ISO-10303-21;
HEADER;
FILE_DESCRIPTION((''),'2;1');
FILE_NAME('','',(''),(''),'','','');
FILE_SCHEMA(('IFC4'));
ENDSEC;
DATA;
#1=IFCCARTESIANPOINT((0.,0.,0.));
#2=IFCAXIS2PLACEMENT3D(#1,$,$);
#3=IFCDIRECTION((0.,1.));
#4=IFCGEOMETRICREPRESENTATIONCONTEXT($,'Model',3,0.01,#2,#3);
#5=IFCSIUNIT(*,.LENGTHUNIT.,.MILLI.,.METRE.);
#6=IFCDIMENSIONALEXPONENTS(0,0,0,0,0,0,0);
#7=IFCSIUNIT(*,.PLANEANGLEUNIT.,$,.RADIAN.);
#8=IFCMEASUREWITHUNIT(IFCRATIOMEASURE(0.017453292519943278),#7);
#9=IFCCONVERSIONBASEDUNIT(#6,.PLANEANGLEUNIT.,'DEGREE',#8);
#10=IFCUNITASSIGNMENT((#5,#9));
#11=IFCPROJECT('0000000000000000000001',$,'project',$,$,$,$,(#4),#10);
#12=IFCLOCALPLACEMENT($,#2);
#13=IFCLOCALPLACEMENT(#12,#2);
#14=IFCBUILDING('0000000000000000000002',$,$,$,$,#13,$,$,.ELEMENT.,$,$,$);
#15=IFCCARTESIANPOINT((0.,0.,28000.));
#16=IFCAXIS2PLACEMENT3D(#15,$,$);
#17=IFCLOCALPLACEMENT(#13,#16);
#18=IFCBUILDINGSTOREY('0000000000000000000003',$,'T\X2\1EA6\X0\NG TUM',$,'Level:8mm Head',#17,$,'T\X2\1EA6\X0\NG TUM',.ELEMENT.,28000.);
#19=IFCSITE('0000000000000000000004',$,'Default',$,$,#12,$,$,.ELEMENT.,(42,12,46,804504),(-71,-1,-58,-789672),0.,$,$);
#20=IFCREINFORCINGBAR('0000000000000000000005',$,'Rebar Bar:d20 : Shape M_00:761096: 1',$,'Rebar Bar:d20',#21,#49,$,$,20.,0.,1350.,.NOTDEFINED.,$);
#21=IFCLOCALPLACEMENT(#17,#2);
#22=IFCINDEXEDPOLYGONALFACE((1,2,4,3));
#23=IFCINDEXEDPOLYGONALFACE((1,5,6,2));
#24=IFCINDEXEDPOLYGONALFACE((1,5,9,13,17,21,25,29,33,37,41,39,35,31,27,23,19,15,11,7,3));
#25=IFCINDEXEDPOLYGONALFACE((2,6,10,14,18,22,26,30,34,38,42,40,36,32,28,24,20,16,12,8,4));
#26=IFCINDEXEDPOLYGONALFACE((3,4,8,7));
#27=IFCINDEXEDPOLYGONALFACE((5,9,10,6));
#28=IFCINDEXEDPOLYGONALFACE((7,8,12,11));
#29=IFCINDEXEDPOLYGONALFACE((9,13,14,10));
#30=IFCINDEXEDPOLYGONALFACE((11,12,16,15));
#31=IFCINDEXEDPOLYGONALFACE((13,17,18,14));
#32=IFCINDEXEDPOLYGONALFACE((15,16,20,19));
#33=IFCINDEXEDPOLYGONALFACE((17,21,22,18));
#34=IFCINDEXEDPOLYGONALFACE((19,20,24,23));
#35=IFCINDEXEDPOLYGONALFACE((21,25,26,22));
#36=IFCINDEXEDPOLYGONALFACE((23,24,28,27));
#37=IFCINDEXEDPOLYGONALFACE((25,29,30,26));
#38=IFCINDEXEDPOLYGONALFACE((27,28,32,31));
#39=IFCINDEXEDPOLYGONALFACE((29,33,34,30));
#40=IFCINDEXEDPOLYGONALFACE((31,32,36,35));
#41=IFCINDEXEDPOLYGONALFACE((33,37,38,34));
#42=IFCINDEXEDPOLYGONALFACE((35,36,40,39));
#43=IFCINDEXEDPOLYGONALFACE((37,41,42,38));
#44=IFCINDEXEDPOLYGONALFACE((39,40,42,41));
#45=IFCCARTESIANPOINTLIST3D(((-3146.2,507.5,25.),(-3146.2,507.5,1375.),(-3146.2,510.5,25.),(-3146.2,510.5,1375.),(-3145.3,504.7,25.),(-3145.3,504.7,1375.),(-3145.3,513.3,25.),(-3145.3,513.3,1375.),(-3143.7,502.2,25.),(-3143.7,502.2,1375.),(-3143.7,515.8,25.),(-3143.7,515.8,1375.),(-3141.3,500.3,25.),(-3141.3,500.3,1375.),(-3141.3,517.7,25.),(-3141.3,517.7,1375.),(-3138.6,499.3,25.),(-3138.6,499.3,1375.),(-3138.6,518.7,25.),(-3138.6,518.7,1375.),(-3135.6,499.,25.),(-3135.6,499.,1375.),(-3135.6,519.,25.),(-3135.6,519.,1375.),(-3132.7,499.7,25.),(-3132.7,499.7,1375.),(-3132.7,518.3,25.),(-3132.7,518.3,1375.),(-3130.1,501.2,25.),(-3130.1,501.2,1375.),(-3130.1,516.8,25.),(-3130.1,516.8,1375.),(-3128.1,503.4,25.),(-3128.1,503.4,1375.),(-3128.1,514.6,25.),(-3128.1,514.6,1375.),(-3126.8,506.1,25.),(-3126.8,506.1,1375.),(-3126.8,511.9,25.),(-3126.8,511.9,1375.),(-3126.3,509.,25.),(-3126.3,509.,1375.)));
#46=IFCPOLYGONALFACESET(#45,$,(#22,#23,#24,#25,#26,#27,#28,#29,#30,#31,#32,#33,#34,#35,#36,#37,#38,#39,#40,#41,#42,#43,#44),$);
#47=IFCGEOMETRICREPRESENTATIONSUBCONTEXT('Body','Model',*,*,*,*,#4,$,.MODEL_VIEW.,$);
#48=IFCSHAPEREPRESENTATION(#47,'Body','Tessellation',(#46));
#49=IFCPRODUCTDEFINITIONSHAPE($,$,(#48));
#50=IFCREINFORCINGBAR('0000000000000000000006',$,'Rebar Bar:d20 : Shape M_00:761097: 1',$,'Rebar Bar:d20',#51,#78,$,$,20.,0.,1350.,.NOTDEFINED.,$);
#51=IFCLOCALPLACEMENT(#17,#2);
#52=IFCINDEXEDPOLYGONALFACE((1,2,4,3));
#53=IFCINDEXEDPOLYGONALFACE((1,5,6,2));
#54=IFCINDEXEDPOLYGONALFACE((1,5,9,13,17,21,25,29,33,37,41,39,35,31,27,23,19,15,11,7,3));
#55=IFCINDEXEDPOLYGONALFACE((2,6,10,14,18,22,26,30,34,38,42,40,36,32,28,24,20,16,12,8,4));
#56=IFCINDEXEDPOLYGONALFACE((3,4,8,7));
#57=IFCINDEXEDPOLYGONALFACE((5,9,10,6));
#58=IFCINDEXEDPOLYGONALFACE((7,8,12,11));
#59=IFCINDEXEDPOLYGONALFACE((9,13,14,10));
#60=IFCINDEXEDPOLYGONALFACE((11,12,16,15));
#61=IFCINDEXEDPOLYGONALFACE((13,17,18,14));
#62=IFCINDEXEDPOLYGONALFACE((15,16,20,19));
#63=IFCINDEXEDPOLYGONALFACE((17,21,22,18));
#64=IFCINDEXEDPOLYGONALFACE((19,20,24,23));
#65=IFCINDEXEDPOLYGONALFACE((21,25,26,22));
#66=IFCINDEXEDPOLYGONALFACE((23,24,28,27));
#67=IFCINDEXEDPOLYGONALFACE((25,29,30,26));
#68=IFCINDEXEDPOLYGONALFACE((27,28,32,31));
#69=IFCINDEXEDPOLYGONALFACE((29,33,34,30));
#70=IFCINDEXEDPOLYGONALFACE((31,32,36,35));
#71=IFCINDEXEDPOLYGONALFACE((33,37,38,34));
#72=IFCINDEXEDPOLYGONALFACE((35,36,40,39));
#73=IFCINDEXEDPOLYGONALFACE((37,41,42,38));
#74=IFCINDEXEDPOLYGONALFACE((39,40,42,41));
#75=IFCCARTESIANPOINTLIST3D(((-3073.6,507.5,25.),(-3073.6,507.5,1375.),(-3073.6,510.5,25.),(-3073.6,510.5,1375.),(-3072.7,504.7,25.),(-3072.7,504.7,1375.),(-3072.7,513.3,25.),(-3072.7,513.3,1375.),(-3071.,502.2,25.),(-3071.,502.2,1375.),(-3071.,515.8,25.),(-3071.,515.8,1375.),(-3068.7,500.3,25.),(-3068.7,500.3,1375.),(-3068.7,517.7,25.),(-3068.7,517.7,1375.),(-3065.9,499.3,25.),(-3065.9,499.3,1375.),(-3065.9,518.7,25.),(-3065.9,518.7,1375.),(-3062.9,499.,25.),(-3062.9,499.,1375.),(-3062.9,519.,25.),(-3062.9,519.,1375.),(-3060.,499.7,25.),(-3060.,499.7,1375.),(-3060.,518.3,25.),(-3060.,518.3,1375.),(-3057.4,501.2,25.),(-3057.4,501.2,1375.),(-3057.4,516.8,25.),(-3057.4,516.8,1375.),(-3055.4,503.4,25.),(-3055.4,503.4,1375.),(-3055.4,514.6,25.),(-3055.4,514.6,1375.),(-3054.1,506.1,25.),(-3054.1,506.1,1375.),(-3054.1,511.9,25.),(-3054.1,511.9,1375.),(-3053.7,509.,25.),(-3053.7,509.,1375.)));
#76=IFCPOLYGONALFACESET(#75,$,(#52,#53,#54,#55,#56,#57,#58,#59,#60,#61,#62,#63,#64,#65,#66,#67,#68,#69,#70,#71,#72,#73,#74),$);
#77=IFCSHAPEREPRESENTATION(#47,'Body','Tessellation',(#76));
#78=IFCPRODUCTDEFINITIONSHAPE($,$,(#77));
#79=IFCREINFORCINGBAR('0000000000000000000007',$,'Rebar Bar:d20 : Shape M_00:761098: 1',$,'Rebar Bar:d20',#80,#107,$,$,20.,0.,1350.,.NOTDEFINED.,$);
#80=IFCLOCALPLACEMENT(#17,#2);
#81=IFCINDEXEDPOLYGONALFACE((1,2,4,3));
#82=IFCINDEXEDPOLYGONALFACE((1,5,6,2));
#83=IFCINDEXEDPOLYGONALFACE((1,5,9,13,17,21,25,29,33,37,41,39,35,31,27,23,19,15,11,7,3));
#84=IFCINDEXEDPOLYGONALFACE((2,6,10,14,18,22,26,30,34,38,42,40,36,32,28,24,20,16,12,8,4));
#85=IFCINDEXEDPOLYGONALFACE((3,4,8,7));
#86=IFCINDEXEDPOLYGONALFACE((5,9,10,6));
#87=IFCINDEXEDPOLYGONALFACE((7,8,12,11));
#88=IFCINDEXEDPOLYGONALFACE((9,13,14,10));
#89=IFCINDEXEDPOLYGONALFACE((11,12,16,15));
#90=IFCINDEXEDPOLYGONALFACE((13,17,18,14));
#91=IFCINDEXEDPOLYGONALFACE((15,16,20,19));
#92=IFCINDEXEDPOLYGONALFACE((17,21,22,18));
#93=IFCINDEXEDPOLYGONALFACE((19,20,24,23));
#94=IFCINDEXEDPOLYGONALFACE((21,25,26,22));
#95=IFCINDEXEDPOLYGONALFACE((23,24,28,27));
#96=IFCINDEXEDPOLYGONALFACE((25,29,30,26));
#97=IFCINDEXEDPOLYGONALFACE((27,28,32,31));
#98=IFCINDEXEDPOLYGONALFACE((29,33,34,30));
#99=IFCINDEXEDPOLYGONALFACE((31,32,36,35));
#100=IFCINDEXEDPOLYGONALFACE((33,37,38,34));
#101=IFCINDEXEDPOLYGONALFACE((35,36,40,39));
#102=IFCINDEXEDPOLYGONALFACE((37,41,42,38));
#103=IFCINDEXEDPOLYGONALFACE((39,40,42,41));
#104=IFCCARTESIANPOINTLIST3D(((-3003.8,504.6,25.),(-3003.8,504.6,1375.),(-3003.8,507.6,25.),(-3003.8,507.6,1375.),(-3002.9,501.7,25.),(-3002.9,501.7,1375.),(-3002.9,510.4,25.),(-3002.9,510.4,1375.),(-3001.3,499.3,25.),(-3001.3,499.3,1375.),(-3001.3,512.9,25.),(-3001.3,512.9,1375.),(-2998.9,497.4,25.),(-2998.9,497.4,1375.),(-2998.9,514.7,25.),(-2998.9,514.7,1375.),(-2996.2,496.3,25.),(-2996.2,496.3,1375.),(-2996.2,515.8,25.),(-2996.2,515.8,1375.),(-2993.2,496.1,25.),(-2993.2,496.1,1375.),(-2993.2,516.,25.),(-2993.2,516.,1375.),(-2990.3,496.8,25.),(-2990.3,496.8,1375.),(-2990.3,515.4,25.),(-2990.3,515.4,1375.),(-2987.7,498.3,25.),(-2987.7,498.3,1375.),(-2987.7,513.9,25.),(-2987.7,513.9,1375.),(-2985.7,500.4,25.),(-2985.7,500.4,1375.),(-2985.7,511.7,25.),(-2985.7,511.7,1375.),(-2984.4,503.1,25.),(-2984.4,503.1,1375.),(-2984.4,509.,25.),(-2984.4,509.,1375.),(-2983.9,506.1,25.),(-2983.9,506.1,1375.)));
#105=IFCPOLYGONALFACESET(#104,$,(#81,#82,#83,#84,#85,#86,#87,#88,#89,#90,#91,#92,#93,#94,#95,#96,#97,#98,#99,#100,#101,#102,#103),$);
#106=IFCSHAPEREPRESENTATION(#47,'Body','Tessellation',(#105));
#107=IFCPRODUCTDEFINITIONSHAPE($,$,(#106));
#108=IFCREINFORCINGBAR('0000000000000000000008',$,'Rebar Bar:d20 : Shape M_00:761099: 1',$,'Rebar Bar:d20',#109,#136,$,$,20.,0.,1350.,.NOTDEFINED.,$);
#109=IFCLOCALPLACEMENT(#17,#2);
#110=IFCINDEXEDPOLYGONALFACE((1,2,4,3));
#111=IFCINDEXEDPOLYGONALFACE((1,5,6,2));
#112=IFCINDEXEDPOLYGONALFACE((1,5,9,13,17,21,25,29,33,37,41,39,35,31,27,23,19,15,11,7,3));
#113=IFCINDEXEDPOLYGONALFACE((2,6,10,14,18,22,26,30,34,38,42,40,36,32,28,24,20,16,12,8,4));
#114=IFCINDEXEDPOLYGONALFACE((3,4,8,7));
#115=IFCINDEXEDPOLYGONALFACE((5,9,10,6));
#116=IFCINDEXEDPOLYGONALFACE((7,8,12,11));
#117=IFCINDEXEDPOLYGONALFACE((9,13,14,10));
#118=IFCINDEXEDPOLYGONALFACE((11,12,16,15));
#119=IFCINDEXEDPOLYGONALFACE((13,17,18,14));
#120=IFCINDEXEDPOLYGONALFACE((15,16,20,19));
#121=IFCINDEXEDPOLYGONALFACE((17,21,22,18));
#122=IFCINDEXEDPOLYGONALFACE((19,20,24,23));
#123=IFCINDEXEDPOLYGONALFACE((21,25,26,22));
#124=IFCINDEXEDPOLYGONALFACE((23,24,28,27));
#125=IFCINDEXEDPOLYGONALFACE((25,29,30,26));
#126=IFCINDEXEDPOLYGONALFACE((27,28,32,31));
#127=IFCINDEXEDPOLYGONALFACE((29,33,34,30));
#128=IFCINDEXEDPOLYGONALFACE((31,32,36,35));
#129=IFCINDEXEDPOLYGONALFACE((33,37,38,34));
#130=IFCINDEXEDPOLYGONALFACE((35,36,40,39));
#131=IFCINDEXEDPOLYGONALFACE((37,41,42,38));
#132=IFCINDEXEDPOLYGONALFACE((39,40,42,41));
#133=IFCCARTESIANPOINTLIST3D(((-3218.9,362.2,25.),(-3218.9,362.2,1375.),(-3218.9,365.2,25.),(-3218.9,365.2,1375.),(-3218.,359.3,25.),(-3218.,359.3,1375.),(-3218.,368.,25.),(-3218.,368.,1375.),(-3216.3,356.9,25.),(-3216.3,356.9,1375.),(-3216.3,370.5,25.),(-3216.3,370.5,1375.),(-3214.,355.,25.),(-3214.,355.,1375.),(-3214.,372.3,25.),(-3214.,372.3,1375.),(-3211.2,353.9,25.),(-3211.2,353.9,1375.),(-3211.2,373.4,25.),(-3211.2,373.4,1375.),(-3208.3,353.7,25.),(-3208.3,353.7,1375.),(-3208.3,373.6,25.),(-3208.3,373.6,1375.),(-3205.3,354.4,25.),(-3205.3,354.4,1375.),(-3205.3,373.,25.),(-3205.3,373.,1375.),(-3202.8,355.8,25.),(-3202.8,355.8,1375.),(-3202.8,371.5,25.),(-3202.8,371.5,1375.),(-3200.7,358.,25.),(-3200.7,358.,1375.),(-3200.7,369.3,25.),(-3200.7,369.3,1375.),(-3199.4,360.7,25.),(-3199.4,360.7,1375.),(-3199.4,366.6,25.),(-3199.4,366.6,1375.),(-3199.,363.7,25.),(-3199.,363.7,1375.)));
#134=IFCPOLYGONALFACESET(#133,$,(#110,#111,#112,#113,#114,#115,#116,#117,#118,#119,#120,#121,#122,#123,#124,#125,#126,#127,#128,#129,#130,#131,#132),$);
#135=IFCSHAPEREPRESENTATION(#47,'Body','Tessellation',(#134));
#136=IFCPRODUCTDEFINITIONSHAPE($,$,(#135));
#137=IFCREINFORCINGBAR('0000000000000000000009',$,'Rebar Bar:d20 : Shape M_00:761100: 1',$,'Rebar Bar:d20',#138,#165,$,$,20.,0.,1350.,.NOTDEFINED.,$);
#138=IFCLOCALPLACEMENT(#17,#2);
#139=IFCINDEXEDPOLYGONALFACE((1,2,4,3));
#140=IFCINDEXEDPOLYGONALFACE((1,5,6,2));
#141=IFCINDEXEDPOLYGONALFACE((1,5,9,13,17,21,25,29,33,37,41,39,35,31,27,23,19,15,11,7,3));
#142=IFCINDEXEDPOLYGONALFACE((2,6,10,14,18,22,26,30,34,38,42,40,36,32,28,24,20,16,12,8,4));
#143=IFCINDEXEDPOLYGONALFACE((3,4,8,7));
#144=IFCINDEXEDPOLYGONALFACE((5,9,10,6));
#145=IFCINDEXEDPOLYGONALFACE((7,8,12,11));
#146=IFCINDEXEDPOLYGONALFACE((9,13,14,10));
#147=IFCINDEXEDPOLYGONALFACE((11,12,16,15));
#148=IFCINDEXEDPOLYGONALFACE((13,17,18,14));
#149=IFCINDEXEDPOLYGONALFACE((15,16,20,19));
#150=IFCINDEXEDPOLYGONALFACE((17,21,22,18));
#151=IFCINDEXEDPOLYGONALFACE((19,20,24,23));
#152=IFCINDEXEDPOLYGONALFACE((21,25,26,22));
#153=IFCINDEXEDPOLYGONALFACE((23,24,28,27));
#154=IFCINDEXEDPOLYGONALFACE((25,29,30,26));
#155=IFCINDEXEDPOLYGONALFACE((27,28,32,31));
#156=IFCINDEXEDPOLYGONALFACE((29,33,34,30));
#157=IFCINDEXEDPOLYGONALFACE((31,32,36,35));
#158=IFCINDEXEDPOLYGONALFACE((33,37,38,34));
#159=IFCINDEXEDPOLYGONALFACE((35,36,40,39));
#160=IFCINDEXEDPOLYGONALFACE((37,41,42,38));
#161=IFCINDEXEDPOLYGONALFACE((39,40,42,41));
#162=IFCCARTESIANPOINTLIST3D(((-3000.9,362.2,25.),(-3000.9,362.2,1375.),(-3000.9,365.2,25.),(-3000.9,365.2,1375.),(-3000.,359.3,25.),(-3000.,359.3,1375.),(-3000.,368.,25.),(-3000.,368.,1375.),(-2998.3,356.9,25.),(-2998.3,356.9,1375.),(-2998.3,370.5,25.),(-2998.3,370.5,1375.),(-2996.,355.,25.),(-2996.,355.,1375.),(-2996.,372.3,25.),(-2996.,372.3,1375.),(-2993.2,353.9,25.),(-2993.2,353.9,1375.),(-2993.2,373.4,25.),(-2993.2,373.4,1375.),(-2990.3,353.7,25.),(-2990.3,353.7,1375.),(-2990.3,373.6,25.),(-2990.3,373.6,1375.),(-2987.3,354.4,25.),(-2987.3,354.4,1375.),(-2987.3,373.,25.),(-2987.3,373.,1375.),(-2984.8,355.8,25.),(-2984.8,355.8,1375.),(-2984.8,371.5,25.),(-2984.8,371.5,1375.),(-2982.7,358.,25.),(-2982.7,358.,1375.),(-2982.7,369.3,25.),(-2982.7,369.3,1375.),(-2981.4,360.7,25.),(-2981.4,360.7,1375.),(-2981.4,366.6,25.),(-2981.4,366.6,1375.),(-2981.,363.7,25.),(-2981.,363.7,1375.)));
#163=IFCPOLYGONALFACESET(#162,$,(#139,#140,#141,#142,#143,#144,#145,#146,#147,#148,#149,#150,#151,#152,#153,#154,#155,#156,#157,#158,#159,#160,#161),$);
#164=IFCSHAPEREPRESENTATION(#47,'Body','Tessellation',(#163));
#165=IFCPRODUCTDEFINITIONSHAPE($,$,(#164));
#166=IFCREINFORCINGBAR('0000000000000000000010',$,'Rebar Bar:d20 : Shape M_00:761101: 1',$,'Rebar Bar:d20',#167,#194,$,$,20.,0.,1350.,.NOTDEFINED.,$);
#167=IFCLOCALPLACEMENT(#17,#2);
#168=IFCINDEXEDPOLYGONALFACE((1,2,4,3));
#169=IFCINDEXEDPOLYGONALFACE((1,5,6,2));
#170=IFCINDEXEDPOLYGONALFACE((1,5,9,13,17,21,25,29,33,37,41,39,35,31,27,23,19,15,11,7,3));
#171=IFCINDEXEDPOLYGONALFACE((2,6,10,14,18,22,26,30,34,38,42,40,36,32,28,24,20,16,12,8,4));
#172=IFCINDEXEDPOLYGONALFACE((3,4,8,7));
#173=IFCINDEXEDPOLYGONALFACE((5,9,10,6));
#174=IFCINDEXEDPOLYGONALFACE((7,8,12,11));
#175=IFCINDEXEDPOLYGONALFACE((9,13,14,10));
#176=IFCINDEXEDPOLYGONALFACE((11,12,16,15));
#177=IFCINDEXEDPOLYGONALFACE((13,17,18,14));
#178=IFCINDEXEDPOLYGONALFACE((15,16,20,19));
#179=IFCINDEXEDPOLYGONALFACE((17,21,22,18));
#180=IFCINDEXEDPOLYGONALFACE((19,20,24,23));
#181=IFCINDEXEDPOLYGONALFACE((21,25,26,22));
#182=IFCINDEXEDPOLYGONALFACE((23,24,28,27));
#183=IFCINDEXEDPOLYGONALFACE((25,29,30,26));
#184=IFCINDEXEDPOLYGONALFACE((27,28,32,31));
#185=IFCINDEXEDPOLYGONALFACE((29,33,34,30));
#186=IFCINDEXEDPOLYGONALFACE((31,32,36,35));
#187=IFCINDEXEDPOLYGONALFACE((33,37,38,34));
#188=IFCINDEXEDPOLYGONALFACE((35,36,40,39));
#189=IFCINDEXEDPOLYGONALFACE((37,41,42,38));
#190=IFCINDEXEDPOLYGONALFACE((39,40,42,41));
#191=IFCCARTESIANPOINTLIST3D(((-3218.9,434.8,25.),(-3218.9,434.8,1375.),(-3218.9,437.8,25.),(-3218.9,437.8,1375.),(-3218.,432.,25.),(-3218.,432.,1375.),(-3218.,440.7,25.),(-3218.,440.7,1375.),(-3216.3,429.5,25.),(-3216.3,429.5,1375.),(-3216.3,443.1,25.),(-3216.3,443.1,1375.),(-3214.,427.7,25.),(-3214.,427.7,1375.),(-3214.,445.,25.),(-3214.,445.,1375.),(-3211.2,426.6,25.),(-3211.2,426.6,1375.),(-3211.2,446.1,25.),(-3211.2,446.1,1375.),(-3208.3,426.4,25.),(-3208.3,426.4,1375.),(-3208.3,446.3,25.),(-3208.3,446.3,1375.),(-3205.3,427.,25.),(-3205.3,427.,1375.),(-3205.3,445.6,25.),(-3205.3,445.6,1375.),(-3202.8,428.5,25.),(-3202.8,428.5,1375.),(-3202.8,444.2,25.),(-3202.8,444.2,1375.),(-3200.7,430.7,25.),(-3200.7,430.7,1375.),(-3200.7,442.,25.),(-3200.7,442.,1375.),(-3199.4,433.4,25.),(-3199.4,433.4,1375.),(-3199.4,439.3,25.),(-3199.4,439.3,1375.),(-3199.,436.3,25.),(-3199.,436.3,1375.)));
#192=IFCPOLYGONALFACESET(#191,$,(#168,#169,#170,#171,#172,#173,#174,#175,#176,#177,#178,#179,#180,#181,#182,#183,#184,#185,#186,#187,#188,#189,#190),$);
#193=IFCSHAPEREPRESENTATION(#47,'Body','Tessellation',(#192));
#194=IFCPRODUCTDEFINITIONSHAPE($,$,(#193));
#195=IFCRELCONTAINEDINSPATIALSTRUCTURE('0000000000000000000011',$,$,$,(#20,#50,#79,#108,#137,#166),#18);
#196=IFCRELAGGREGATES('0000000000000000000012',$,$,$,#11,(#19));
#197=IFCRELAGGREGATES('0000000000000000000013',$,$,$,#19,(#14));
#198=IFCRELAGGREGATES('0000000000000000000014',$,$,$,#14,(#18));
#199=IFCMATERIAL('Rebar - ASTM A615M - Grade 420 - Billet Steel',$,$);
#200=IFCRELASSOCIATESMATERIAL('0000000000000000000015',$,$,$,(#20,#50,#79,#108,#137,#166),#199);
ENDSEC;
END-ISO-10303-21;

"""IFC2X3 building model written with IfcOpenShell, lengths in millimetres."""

from ifc_helpers import new_model, entity, si_unit, converted_unit, direction, frame, origin, place, context, subcontext, project, spatial, material, element, save


model = new_model("IFC2X3")

# Units and contexts
model_context = context("Model", 3, precision=0.01, world=origin(), true_north=direction((0.0, 1.0)))
body_context = subcontext(model_context, "Body", "Model", "MODEL_VIEW")
ifc_project = project(units=[si_unit("LENGTHUNIT", "METRE", prefix="MILLI"), converted_unit("PLANEANGLEUNIT", "DEGREE", entity("IfcRatioMeasure", 0.017453292519943278), si_unit("PLANEANGLEUNIT", "RADIAN"), dimensions=[0, 0, 0, 0, 0, 0, 0])], contexts=[model_context])

# Site, building, storey
site_placement = place(None, origin())
site = spatial("IfcSite", under=ifc_project, at=site_placement, Name="Default", CompositionType="ELEMENT", RefLatitude=(42, 12, 46, 804504), RefLongitude=(-71, -1, -58, -789672), RefElevation=0.0)
building_placement = place(site_placement, origin())
building = spatial("IfcBuilding", under=site, at=building_placement, CompositionType="ELEMENT")
storey_placement = place(building_placement, frame((0.0, 0.0, 28000.0)))
storey = spatial("IfcBuildingStorey", under=building, at=storey_placement, Name="TẦNG TUM", ObjectType="Level:8mm Head", LongName="TẦNG TUM", CompositionType="ELEMENT", Elevation=28000.0)

# Reinforcing bars
ifc_material = material(Name="Rebar - ASTM A615M - Grade 420 - Billet Steel")
reinforcing_bar_1_placement = place(storey_placement, origin())
element("IfcReinforcingBar", 1, at=reinforcing_bar_1_placement, inside=storey, material=ifc_material, Name="Rebar Bar:d20 : Shape M_00:761096: 1", ObjectType="Rebar Bar:d20", BarLength=1350.0, BarRole="NOTDEFINED", CrossSectionArea=0.0, NominalDiameter=20.0, context=body_context, shape_type="AdvancedSweptSolid", body=[
    entity("IfcSweptDiskSolid", entity("IfcCompositeCurve", [entity("IfcCompositeCurveSegment", "CONTINUOUS", True, entity("IfcPolyline", [entity("IfcCartesianPoint", [-3136.3, 509.0, 25.0]), entity("IfcCartesianPoint", [-3136.3, 509.0, 1375.0])]))], False), 10.0, None, 0.0, 1.0),
])
reinforcing_bar_2_placement = place(storey_placement, origin())
element("IfcReinforcingBar", 2, at=reinforcing_bar_2_placement, inside=storey, material=ifc_material, Name="Rebar Bar:d20 : Shape M_00:761097: 1", ObjectType="Rebar Bar:d20", BarLength=1350.0, BarRole="NOTDEFINED", CrossSectionArea=0.0, NominalDiameter=20.0, context=body_context, shape_type="AdvancedSweptSolid", body=[
    entity("IfcSweptDiskSolid", entity("IfcCompositeCurve", [entity("IfcCompositeCurveSegment", "CONTINUOUS", True, entity("IfcPolyline", [entity("IfcCartesianPoint", [-3063.7, 509.0, 25.0]), entity("IfcCartesianPoint", [-3063.7, 509.0, 1375.0])]))], False), 10.0, None, 0.0, 1.0),
])
reinforcing_bar_3_placement = place(storey_placement, origin())
element("IfcReinforcingBar", 3, at=reinforcing_bar_3_placement, inside=storey, material=ifc_material, Name="Rebar Bar:d20 : Shape M_00:761098: 1", ObjectType="Rebar Bar:d20", BarLength=1350.0, BarRole="NOTDEFINED", CrossSectionArea=0.0, NominalDiameter=20.0, context=body_context, shape_type="AdvancedSweptSolid", body=[
    entity("IfcSweptDiskSolid", entity("IfcCompositeCurve", [entity("IfcCompositeCurveSegment", "CONTINUOUS", True, entity("IfcPolyline", [entity("IfcCartesianPoint", [-2993.9, 506.1, 25.0]), entity("IfcCartesianPoint", [-2993.9, 506.1, 1375.0])]))], False), 10.0, None, 0.0, 1.0),
])
reinforcing_bar_4_placement = place(storey_placement, origin())
element("IfcReinforcingBar", 4, at=reinforcing_bar_4_placement, inside=storey, material=ifc_material, Name="Rebar Bar:d20 : Shape M_00:761099: 1", ObjectType="Rebar Bar:d20", BarLength=1350.0, BarRole="NOTDEFINED", CrossSectionArea=0.0, NominalDiameter=20.0, context=body_context, shape_type="AdvancedSweptSolid", body=[
    entity("IfcSweptDiskSolid", entity("IfcCompositeCurve", [entity("IfcCompositeCurveSegment", "CONTINUOUS", True, entity("IfcPolyline", [entity("IfcCartesianPoint", [-3209.0, 363.7, 25.0]), entity("IfcCartesianPoint", [-3209.0, 363.7, 1375.0])]))], False), 10.0, None, 0.0, 1.0),
])
reinforcing_bar_5_placement = place(storey_placement, origin())
element("IfcReinforcingBar", 5, at=reinforcing_bar_5_placement, inside=storey, material=ifc_material, Name="Rebar Bar:d20 : Shape M_00:761100: 1", ObjectType="Rebar Bar:d20", BarLength=1350.0, BarRole="NOTDEFINED", CrossSectionArea=0.0, NominalDiameter=20.0, context=body_context, shape_type="AdvancedSweptSolid", body=[
    entity("IfcSweptDiskSolid", entity("IfcCompositeCurve", [entity("IfcCompositeCurveSegment", "CONTINUOUS", True, entity("IfcPolyline", [entity("IfcCartesianPoint", [-2991.0, 363.7, 25.0]), entity("IfcCartesianPoint", [-2991.0, 363.7, 1375.0])]))], False), 10.0, None, 0.0, 1.0),
])
reinforcing_bar_6_placement = place(storey_placement, origin())
element("IfcReinforcingBar", 6, at=reinforcing_bar_6_placement, inside=storey, material=ifc_material, Name="Rebar Bar:d20 : Shape M_00:761101: 1", ObjectType="Rebar Bar:d20", BarLength=1350.0, BarRole="NOTDEFINED", CrossSectionArea=0.0, NominalDiameter=20.0, context=body_context, shape_type="AdvancedSweptSolid", body=[
    entity("IfcSweptDiskSolid", entity("IfcCompositeCurve", [entity("IfcCompositeCurveSegment", "CONTINUOUS", True, entity("IfcPolyline", [entity("IfcCartesianPoint", [-3209.0, 436.3, 25.0]), entity("IfcCartesianPoint", [-3209.0, 436.3, 1375.0])]))], False), 10.0, None, 0.0, 1.0),
])

save(model, "model.ifc")
